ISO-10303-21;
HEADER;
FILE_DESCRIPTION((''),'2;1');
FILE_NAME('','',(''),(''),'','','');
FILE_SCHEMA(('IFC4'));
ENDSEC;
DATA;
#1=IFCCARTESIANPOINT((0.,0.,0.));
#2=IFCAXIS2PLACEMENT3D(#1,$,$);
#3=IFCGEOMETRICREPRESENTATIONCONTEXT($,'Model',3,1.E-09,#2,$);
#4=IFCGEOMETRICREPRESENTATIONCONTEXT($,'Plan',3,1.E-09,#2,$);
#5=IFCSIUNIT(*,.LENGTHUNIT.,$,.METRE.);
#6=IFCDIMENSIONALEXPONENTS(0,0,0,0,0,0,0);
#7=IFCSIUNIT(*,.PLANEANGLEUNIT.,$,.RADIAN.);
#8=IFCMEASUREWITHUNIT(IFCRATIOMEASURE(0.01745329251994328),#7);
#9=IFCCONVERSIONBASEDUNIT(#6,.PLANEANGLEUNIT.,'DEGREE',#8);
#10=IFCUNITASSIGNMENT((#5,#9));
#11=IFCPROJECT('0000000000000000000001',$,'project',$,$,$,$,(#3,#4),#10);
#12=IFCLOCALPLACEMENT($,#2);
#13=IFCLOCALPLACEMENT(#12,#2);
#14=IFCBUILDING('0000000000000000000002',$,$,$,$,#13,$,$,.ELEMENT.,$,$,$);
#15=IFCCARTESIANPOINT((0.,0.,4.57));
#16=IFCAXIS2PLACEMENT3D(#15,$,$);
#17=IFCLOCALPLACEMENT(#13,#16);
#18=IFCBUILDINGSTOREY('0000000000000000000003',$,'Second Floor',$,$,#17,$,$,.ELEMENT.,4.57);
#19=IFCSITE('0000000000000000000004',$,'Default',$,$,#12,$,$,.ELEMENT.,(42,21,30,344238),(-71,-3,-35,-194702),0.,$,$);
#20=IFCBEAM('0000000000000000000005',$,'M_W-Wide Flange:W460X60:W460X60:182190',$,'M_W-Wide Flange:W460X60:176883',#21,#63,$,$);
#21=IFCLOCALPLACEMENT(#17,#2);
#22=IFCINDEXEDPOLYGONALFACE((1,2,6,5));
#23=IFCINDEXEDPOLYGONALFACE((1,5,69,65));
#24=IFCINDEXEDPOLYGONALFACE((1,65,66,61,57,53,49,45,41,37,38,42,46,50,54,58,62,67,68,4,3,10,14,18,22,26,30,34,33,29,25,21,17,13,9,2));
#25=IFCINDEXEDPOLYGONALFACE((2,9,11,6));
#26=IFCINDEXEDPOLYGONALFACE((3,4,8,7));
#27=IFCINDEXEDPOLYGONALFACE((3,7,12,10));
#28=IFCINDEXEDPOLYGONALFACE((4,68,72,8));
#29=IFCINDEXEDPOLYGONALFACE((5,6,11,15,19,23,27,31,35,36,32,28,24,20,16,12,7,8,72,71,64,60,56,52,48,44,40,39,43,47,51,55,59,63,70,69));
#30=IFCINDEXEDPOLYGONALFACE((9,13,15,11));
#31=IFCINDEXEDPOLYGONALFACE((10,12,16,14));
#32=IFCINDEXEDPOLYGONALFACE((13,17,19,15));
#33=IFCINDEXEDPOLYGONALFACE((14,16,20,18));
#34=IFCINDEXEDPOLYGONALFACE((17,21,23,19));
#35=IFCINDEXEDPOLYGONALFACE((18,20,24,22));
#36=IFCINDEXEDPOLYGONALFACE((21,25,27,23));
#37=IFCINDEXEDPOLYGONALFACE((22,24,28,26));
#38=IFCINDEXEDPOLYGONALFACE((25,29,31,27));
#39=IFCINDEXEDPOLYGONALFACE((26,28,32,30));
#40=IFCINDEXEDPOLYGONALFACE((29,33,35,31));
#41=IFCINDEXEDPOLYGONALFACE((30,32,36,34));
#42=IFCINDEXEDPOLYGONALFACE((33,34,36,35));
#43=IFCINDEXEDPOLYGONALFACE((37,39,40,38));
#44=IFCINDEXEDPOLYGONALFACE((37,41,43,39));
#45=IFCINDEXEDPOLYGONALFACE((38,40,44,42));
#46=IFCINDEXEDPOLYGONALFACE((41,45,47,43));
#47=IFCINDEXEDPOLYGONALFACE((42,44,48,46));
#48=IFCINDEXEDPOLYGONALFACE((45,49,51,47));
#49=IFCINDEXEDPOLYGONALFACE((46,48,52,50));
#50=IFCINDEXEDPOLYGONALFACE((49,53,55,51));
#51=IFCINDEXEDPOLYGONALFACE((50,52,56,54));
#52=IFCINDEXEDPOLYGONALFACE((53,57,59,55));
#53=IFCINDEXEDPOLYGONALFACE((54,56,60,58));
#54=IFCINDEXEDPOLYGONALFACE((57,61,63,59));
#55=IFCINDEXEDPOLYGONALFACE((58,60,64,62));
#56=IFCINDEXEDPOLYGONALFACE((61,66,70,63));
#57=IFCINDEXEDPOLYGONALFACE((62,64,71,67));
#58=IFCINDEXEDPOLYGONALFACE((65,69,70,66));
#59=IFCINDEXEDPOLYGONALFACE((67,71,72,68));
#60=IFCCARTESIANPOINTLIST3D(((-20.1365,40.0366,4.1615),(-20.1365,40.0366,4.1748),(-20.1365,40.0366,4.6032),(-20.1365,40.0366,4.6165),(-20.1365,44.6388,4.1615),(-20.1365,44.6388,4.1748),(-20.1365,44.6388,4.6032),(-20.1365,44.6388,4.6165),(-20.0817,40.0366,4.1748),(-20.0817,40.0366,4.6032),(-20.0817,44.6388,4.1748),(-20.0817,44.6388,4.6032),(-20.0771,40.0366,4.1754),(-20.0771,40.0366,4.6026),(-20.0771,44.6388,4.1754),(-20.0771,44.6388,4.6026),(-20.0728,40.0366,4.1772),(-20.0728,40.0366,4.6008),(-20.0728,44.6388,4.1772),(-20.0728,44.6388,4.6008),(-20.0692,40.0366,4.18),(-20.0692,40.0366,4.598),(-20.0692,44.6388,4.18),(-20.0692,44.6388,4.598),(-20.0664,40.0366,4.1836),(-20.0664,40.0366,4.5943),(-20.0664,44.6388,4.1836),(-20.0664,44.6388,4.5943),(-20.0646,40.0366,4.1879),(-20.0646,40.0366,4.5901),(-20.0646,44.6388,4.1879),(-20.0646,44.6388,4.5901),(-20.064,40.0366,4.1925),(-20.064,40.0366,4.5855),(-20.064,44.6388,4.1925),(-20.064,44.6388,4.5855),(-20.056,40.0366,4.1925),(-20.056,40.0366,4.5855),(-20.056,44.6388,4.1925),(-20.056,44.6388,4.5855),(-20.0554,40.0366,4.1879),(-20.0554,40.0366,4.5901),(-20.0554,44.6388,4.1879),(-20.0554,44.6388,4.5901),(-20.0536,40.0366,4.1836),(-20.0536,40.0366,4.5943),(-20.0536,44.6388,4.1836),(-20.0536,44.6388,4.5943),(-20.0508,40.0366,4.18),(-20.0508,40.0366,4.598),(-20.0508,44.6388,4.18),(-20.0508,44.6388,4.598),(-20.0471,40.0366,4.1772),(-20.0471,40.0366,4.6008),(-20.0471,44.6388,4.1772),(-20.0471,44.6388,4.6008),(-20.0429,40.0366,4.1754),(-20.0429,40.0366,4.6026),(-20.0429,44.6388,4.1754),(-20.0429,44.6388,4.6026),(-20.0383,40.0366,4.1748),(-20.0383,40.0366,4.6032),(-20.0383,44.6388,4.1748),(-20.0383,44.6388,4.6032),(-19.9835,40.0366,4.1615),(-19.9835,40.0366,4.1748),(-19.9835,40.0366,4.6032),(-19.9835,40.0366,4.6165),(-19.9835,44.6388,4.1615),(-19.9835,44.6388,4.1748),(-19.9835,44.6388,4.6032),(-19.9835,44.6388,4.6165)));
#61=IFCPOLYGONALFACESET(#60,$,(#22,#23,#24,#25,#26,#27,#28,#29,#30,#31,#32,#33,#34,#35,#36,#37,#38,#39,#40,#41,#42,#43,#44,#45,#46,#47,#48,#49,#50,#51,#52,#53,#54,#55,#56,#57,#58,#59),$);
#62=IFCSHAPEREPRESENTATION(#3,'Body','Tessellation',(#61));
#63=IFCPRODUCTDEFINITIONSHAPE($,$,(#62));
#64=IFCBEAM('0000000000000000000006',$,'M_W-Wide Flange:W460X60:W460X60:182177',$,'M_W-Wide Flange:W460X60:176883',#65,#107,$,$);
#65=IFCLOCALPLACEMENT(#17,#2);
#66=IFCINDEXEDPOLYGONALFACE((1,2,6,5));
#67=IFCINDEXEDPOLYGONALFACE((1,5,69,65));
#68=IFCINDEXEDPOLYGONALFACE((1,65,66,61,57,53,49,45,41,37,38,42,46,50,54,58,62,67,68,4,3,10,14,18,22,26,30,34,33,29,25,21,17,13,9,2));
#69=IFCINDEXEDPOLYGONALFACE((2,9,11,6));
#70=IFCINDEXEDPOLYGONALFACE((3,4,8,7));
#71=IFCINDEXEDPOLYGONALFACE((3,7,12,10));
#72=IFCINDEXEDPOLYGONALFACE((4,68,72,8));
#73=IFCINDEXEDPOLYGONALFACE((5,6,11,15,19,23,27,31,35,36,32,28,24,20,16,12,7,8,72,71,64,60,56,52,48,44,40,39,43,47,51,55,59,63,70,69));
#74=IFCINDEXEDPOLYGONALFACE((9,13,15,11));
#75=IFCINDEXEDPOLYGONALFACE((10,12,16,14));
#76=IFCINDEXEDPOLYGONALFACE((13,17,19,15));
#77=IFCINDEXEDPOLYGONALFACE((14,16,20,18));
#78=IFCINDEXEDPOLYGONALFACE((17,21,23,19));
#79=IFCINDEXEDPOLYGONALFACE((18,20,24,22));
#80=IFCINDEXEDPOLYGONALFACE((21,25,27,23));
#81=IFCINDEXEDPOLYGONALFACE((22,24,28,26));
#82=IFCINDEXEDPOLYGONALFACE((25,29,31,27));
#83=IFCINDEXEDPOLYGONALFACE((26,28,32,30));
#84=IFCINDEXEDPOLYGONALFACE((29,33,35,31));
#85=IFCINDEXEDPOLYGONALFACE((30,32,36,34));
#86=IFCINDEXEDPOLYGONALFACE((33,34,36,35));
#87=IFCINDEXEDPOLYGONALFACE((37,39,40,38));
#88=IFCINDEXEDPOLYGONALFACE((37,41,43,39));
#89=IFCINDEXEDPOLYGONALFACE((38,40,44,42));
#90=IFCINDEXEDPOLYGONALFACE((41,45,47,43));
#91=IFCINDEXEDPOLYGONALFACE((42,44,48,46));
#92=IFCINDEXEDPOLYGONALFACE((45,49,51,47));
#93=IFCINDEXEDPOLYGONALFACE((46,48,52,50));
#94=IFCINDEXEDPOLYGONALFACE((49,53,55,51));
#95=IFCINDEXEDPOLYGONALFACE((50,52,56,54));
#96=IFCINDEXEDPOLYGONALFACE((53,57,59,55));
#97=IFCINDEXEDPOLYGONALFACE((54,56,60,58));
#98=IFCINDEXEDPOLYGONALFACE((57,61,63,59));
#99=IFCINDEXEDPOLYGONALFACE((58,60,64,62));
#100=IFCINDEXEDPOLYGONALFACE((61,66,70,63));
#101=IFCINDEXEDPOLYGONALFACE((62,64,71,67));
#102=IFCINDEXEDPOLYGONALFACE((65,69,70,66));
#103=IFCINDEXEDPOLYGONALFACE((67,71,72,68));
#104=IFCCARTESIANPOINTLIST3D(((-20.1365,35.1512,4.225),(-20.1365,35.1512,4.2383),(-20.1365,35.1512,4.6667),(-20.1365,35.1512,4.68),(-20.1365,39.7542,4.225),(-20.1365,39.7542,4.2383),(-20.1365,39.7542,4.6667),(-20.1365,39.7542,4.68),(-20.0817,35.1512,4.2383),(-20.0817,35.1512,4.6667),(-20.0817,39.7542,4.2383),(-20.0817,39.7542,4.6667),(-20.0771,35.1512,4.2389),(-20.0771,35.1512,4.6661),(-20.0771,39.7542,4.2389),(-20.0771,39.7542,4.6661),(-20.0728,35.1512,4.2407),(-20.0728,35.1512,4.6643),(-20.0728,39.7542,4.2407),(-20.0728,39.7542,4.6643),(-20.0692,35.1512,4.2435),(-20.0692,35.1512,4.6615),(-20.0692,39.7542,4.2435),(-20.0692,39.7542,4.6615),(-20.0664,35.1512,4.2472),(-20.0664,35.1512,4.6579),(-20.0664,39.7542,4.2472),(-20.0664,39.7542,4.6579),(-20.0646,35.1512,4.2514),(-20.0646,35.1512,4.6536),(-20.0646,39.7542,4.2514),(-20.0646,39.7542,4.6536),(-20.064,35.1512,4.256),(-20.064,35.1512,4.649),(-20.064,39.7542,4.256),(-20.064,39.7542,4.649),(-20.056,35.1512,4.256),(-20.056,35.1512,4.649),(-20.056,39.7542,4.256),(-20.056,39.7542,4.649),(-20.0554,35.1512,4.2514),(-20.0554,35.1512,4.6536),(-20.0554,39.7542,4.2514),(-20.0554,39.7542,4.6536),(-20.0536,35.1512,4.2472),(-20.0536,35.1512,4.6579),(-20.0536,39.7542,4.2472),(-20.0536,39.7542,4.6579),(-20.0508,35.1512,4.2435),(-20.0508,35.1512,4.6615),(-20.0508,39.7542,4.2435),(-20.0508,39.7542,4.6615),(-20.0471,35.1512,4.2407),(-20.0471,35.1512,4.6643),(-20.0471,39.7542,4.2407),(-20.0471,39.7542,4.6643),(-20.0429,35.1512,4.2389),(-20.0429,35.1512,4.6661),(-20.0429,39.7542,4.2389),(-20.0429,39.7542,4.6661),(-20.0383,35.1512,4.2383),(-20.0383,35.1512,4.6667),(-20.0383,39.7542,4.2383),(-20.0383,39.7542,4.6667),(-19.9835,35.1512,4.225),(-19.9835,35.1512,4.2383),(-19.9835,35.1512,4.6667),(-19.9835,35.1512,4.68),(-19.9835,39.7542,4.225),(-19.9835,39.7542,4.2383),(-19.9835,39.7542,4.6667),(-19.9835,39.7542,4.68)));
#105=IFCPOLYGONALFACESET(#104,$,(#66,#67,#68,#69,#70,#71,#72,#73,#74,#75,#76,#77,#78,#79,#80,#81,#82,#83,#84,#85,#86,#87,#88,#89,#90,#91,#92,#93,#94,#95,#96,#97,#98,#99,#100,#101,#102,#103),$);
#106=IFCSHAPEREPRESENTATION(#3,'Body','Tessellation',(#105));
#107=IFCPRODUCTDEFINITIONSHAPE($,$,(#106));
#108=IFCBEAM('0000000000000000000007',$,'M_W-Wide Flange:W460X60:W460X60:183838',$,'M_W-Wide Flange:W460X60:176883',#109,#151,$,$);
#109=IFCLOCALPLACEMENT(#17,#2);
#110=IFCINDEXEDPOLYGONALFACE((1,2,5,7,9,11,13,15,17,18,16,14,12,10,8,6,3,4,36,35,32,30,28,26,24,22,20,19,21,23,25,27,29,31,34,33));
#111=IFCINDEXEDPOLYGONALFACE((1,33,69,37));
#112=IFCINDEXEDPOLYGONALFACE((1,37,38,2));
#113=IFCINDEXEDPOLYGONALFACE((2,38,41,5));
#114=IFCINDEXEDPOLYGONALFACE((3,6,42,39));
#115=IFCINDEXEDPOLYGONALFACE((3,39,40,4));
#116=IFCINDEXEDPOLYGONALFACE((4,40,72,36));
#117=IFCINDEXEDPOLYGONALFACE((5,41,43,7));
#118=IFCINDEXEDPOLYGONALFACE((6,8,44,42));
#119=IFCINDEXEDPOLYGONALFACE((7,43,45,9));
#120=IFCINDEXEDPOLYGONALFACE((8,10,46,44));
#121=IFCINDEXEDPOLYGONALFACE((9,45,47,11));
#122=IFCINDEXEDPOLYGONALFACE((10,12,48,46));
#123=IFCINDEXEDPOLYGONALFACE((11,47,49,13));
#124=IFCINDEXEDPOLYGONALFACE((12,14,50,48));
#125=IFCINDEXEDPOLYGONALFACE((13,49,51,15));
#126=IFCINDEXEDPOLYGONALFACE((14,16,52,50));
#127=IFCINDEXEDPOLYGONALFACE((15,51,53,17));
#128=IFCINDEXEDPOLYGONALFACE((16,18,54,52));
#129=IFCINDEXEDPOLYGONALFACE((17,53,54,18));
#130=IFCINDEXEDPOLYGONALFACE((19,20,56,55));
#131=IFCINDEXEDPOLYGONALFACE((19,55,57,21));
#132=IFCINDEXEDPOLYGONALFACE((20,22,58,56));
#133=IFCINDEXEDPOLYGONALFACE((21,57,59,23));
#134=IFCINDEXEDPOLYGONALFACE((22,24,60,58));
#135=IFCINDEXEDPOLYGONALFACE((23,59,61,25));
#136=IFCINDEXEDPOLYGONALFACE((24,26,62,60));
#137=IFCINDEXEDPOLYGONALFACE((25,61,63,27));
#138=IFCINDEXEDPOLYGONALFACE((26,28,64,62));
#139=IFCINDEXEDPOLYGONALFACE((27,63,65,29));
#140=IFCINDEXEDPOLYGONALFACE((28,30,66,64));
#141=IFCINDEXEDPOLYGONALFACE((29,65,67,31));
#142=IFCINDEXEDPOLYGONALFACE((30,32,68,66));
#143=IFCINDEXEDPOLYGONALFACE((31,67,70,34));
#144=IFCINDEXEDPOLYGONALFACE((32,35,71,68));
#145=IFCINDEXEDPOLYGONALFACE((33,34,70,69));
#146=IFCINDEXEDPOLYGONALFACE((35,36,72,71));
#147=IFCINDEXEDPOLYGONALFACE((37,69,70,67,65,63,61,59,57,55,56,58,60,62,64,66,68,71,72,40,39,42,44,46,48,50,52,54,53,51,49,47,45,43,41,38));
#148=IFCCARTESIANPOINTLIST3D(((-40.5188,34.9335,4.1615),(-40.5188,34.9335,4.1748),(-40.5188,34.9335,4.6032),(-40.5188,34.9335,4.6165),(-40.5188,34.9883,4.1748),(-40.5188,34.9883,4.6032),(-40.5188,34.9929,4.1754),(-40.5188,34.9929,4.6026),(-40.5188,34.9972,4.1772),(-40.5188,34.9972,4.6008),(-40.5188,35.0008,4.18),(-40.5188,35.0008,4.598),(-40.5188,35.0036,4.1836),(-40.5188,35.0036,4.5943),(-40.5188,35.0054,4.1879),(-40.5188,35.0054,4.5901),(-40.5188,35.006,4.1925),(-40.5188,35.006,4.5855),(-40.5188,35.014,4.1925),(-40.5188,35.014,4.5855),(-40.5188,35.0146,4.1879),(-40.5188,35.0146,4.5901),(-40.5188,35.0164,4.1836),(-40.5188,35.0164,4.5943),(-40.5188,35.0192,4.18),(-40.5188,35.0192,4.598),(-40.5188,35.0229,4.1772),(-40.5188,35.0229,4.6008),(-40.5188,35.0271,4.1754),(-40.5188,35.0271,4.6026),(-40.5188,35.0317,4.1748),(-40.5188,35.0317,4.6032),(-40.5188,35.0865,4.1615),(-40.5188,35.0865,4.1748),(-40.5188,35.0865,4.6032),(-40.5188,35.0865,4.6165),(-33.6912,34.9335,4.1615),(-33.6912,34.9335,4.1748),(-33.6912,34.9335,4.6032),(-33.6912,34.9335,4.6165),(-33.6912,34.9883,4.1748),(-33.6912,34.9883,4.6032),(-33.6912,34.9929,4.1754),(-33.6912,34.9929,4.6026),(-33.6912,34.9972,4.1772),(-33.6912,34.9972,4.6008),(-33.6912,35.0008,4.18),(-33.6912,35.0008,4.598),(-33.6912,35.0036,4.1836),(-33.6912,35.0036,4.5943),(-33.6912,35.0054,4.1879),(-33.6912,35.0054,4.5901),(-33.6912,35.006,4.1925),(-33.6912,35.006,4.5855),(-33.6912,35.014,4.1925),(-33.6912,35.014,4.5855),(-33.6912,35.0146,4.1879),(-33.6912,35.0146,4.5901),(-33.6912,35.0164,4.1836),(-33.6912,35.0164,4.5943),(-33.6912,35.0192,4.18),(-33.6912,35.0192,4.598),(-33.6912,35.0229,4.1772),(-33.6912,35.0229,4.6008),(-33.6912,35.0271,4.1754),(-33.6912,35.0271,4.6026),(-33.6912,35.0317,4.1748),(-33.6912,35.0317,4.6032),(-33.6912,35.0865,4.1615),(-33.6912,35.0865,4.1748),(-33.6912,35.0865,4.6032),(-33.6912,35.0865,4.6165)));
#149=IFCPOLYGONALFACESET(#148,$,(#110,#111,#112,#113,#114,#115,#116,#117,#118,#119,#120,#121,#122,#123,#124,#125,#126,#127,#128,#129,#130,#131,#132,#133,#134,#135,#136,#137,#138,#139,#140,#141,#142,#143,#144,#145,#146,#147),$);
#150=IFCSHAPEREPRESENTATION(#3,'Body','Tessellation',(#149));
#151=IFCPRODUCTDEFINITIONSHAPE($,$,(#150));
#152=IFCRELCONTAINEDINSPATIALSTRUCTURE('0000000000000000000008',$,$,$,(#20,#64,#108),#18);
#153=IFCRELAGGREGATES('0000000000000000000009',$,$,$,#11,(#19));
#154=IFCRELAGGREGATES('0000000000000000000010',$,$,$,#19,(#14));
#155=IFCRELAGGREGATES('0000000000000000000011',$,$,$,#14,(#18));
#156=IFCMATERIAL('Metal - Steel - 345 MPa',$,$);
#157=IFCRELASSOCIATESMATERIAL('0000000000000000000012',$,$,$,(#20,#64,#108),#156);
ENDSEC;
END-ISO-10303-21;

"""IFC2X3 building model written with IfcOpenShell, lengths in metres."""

from ifc_helpers import new_model, entity, si_unit, converted_unit, frame, frame_2d, origin, place, context, project, spatial, polyline, circle_curve, parameter, trimmed, segment, composite_curve, outline, extrude, material, element, save


model = new_model("IFC2X3")

# Units and contexts
model_context = context("Model", 3, precision=1e-09, world=origin())
plan_context = context("Plan", 3, precision=1e-09, world=origin())
ifc_project = project(units=[si_unit("LENGTHUNIT", "METRE"), converted_unit("PLANEANGLEUNIT", "DEGREE", entity("IfcRatioMeasure", 0.01745329251994328), si_unit("PLANEANGLEUNIT", "RADIAN"), dimensions=[0, 0, 0, 0, 0, 0, 0])], contexts=[model_context, plan_context])

# Site, building, storey
site_placement = place(None, origin())
site = spatial("IfcSite", under=ifc_project, at=site_placement, Name="Default", CompositionType="ELEMENT", RefLatitude=(42, 21, 30, 344238), RefLongitude=(-71, -3, -35, -194702), RefElevation=0.0)
building_placement = place(site_placement, origin())
building = spatial("IfcBuilding", under=site, at=building_placement, CompositionType="ELEMENT")
storey_placement = place(building_placement, frame((0.0, 0.0, 4.57)))
storey = spatial("IfcBuildingStorey", under=building, at=storey_placement, Name="Second Floor", CompositionType="ELEMENT", Elevation=4.57)

# Shared definitions
ifc_material = material(Name="Metal - Steel - 345 MPa")

# Beams
beam_1_placement = place(storey_placement, frame((-20.06, 39.8992, 4.6165)))
element("IfcBeam", 1, at=beam_1_placement, inside=storey, material=ifc_material, Name="M_W-Wide Flange:W460X60:W460X60:182190", ObjectType="M_W-Wide Flange:W460X60:176883", context=model_context, shape_type="SweptSolid", body=[
    extrude(outline(composite_curve([segment(polyline([(-0.0765, -0.2142), (-0.0765, -0.2275)]), True, "CONTINUOUS"), segment(polyline([(-0.0765, -0.2275), (0.0765, -0.2275)]), True, "CONTINUOUS"), segment(polyline([(0.0765, -0.2275), (0.0765, -0.2142)]), True, "CONTINUOUS"), segment(polyline([(0.0765, -0.2142), (0.0217, -0.2142)]), True, "CONTINUOUS"), segment(trimmed(circle_curve(frame_2d((0.0217, -0.1965), x_axis=(1.0, 0.0)), 0.0177), [parameter(180.0)], [parameter(270.0)], True, "PARAMETER"), False, "CONTINUOUS"), segment(polyline([(0.004, -0.1965), (0.004, 0.1965)]), True, "CONTINUOUS"), segment(trimmed(circle_curve(frame_2d((0.0217, 0.1965), x_axis=(1.0, 0.0)), 0.0177), [parameter(90.0)], [parameter(180.0)], True, "PARAMETER"), False, "CONTINUOUS"), segment(polyline([(0.0217, 0.2142), (0.0765, 0.2142)]), True, "CONTINUOUS"), segment(polyline([(0.0765, 0.2142), (0.0765, 0.2275)]), True, "CONTINUOUS"), segment(polyline([(0.0765, 0.2275), (-0.0765, 0.2275)]), True, "CONTINUOUS"), segment(polyline([(-0.0765, 0.2275), (-0.0765, 0.2142)]), True, "CONTINUOUS"), segment(polyline([(-0.0765, 0.2142), (-0.0217, 0.2142)]), True, "CONTINUOUS"), segment(trimmed(circle_curve(frame_2d((-0.0217, 0.1965), x_axis=(1.0, 0.0)), 0.0177), [parameter(360.0)], [parameter(90.0)], True, "PARAMETER"), False, "CONTINUOUS"), segment(polyline([(-0.004, 0.1965), (-0.004, -0.1965)]), True, "CONTINUOUS"), segment(trimmed(circle_curve(frame_2d((-0.0217, -0.1965), x_axis=(1.0, 0.0)), 0.0177), [parameter(270.0)], [parameter(0.0)], True, "PARAMETER"), False, "CONTINUOUS"), segment(polyline([(-0.0217, -0.2142), (-0.0765, -0.2142)]), True, "CONTINUOUS")], self_intersect=False)), frame((0.0, 0.1373, -0.2275), z_axis=(0.0, -1.0, 0.0), x_axis=(1.0, 0.0, 0.0)), (0.0, 0.0, -1.0), 4.6022),
])
beam_2_placement = place(storey_placement, frame((-20.06, 35.0139, 4.68)))
element("IfcBeam", 2, at=beam_2_placement, inside=storey, material=ifc_material, Name="M_W-Wide Flange:W460X60:W460X60:182177", ObjectType="M_W-Wide Flange:W460X60:176883", context=model_context, shape_type="SweptSolid", body=[
    extrude(outline(composite_curve([segment(polyline([(-0.0765, -0.2142), (-0.0765, -0.2275)]), True, "CONTINUOUS"), segment(polyline([(-0.0765, -0.2275), (0.0765, -0.2275)]), True, "CONTINUOUS"), segment(polyline([(0.0765, -0.2275), (0.0765, -0.2142)]), True, "CONTINUOUS"), segment(polyline([(0.0765, -0.2142), (0.0217, -0.2142)]), True, "CONTINUOUS"), segment(trimmed(circle_curve(frame_2d((0.0217, -0.1965), x_axis=(0.0, -1.0)), 0.0177), [parameter(270.0)], [parameter(360.0)], True, "PARAMETER"), False, "CONTINUOUS"), segment(polyline([(0.004, -0.1965), (0.004, 0.1965)]), True, "CONTINUOUS"), segment(trimmed(circle_curve(frame_2d((0.0217, 0.1965), x_axis=(-1.0, 0.0)), 0.0177), [parameter(270.0)], [parameter(360.0)], True, "PARAMETER"), False, "CONTINUOUS"), segment(polyline([(0.0217, 0.2142), (0.0765, 0.2142)]), True, "CONTINUOUS"), segment(polyline([(0.0765, 0.2142), (0.0765, 0.2275)]), True, "CONTINUOUS"), segment(polyline([(0.0765, 0.2275), (-0.0765, 0.2275)]), True, "CONTINUOUS"), segment(polyline([(-0.0765, 0.2275), (-0.0765, 0.2142)]), True, "CONTINUOUS"), segment(polyline([(-0.0765, 0.2142), (-0.0217, 0.2142)]), True, "CONTINUOUS"), segment(trimmed(circle_curve(frame_2d((-0.0217, 0.1965), x_axis=(0.0, 1.0)), 0.0177), [parameter(270.0)], [parameter(360.0)], True, "PARAMETER"), False, "CONTINUOUS"), segment(polyline([(-0.004, 0.1965), (-0.004, -0.1965)]), True, "CONTINUOUS"), segment(trimmed(circle_curve(frame_2d((-0.0217, -0.1965), x_axis=(1.0, 0.0)), 0.0177), [parameter(270.0)], [parameter(0.0)], True, "PARAMETER"), False, "CONTINUOUS"), segment(polyline([(-0.0217, -0.2142), (-0.0765, -0.2142)]), True, "CONTINUOUS")], self_intersect=False)), frame((0.0, 0.1373, -0.2275), z_axis=(0.0, -1.0, 0.0), x_axis=(1.0, 0.0, 0.0)), (0.0, 0.0, -1.0), 4.603),
])
beam_3_placement = place(storey_placement, frame((-33.5527, 35.01, 4.6165), z_axis=(0.0, 0.0, 1.0), x_axis=(0.0, 1.0, 0.0)))
element("IfcBeam", 3, at=beam_3_placement, inside=storey, material=ifc_material, Name="M_W-Wide Flange:W460X60:W460X60:183838", ObjectType="M_W-Wide Flange:W460X60:176883", context=model_context, shape_type="SweptSolid", body=[
    extrude(outline(composite_curve([segment(polyline([(0.2142, -0.0765), (0.2275, -0.0765)]), True, "CONTINUOUS"), segment(polyline([(0.2275, -0.0765), (0.2275, 0.0765)]), True, "CONTINUOUS"), segment(polyline([(0.2275, 0.0765), (0.2142, 0.0765)]), True, "CONTINUOUS"), segment(polyline([(0.2142, 0.0765), (0.2142, 0.0217)]), True, "CONTINUOUS"), segment(trimmed(circle_curve(frame_2d((0.1965, 0.0217), x_axis=(1.0, 0.0)), 0.0177), [parameter(270.0)], [parameter(360.0)], True, "PARAMETER"), False, "CONTINUOUS"), segment(polyline([(0.1965, 0.004), (-0.1965, 0.004)]), True, "CONTINUOUS"), segment(trimmed(circle_curve(frame_2d((-0.1965, 0.0217), x_axis=(0.0, -1.0)), 0.0177), [parameter(270.0)], [parameter(360.0)], True, "PARAMETER"), False, "CONTINUOUS"), segment(polyline([(-0.2142, 0.0217), (-0.2142, 0.0765)]), True, "CONTINUOUS"), segment(polyline([(-0.2142, 0.0765), (-0.2275, 0.0765)]), True, "CONTINUOUS"), segment(polyline([(-0.2275, 0.0765), (-0.2275, -0.0765)]), True, "CONTINUOUS"), segment(polyline([(-0.2275, -0.0765), (-0.2142, -0.0765)]), True, "CONTINUOUS"), segment(polyline([(-0.2142, -0.0765), (-0.2142, -0.0217)]), True, "CONTINUOUS"), segment(trimmed(circle_curve(frame_2d((-0.1965, -0.0217), x_axis=(-1.0, 0.0)), 0.0177), [parameter(270.0)], [parameter(360.0)], True, "PARAMETER"), False, "CONTINUOUS"), segment(polyline([(-0.1965, -0.004), (0.1965, -0.004)]), True, "CONTINUOUS"), segment(trimmed(circle_curve(frame_2d((0.1965, -0.0217), x_axis=(0.0, 1.0)), 0.0177), [parameter(270.0)], [parameter(0.0)], True, "PARAMETER"), False, "CONTINUOUS"), segment(polyline([(0.2142, -0.0217), (0.2142, -0.0765)]), True, "CONTINUOUS")], self_intersect=False)), frame((0.0, 6.9661, -0.2275), z_axis=(0.0, -1.0, 0.0), x_axis=(0.0, 0.0, -1.0)), (0.0, 0.0, 1.0), 6.8276),
])

save(model, "model.ifc")
